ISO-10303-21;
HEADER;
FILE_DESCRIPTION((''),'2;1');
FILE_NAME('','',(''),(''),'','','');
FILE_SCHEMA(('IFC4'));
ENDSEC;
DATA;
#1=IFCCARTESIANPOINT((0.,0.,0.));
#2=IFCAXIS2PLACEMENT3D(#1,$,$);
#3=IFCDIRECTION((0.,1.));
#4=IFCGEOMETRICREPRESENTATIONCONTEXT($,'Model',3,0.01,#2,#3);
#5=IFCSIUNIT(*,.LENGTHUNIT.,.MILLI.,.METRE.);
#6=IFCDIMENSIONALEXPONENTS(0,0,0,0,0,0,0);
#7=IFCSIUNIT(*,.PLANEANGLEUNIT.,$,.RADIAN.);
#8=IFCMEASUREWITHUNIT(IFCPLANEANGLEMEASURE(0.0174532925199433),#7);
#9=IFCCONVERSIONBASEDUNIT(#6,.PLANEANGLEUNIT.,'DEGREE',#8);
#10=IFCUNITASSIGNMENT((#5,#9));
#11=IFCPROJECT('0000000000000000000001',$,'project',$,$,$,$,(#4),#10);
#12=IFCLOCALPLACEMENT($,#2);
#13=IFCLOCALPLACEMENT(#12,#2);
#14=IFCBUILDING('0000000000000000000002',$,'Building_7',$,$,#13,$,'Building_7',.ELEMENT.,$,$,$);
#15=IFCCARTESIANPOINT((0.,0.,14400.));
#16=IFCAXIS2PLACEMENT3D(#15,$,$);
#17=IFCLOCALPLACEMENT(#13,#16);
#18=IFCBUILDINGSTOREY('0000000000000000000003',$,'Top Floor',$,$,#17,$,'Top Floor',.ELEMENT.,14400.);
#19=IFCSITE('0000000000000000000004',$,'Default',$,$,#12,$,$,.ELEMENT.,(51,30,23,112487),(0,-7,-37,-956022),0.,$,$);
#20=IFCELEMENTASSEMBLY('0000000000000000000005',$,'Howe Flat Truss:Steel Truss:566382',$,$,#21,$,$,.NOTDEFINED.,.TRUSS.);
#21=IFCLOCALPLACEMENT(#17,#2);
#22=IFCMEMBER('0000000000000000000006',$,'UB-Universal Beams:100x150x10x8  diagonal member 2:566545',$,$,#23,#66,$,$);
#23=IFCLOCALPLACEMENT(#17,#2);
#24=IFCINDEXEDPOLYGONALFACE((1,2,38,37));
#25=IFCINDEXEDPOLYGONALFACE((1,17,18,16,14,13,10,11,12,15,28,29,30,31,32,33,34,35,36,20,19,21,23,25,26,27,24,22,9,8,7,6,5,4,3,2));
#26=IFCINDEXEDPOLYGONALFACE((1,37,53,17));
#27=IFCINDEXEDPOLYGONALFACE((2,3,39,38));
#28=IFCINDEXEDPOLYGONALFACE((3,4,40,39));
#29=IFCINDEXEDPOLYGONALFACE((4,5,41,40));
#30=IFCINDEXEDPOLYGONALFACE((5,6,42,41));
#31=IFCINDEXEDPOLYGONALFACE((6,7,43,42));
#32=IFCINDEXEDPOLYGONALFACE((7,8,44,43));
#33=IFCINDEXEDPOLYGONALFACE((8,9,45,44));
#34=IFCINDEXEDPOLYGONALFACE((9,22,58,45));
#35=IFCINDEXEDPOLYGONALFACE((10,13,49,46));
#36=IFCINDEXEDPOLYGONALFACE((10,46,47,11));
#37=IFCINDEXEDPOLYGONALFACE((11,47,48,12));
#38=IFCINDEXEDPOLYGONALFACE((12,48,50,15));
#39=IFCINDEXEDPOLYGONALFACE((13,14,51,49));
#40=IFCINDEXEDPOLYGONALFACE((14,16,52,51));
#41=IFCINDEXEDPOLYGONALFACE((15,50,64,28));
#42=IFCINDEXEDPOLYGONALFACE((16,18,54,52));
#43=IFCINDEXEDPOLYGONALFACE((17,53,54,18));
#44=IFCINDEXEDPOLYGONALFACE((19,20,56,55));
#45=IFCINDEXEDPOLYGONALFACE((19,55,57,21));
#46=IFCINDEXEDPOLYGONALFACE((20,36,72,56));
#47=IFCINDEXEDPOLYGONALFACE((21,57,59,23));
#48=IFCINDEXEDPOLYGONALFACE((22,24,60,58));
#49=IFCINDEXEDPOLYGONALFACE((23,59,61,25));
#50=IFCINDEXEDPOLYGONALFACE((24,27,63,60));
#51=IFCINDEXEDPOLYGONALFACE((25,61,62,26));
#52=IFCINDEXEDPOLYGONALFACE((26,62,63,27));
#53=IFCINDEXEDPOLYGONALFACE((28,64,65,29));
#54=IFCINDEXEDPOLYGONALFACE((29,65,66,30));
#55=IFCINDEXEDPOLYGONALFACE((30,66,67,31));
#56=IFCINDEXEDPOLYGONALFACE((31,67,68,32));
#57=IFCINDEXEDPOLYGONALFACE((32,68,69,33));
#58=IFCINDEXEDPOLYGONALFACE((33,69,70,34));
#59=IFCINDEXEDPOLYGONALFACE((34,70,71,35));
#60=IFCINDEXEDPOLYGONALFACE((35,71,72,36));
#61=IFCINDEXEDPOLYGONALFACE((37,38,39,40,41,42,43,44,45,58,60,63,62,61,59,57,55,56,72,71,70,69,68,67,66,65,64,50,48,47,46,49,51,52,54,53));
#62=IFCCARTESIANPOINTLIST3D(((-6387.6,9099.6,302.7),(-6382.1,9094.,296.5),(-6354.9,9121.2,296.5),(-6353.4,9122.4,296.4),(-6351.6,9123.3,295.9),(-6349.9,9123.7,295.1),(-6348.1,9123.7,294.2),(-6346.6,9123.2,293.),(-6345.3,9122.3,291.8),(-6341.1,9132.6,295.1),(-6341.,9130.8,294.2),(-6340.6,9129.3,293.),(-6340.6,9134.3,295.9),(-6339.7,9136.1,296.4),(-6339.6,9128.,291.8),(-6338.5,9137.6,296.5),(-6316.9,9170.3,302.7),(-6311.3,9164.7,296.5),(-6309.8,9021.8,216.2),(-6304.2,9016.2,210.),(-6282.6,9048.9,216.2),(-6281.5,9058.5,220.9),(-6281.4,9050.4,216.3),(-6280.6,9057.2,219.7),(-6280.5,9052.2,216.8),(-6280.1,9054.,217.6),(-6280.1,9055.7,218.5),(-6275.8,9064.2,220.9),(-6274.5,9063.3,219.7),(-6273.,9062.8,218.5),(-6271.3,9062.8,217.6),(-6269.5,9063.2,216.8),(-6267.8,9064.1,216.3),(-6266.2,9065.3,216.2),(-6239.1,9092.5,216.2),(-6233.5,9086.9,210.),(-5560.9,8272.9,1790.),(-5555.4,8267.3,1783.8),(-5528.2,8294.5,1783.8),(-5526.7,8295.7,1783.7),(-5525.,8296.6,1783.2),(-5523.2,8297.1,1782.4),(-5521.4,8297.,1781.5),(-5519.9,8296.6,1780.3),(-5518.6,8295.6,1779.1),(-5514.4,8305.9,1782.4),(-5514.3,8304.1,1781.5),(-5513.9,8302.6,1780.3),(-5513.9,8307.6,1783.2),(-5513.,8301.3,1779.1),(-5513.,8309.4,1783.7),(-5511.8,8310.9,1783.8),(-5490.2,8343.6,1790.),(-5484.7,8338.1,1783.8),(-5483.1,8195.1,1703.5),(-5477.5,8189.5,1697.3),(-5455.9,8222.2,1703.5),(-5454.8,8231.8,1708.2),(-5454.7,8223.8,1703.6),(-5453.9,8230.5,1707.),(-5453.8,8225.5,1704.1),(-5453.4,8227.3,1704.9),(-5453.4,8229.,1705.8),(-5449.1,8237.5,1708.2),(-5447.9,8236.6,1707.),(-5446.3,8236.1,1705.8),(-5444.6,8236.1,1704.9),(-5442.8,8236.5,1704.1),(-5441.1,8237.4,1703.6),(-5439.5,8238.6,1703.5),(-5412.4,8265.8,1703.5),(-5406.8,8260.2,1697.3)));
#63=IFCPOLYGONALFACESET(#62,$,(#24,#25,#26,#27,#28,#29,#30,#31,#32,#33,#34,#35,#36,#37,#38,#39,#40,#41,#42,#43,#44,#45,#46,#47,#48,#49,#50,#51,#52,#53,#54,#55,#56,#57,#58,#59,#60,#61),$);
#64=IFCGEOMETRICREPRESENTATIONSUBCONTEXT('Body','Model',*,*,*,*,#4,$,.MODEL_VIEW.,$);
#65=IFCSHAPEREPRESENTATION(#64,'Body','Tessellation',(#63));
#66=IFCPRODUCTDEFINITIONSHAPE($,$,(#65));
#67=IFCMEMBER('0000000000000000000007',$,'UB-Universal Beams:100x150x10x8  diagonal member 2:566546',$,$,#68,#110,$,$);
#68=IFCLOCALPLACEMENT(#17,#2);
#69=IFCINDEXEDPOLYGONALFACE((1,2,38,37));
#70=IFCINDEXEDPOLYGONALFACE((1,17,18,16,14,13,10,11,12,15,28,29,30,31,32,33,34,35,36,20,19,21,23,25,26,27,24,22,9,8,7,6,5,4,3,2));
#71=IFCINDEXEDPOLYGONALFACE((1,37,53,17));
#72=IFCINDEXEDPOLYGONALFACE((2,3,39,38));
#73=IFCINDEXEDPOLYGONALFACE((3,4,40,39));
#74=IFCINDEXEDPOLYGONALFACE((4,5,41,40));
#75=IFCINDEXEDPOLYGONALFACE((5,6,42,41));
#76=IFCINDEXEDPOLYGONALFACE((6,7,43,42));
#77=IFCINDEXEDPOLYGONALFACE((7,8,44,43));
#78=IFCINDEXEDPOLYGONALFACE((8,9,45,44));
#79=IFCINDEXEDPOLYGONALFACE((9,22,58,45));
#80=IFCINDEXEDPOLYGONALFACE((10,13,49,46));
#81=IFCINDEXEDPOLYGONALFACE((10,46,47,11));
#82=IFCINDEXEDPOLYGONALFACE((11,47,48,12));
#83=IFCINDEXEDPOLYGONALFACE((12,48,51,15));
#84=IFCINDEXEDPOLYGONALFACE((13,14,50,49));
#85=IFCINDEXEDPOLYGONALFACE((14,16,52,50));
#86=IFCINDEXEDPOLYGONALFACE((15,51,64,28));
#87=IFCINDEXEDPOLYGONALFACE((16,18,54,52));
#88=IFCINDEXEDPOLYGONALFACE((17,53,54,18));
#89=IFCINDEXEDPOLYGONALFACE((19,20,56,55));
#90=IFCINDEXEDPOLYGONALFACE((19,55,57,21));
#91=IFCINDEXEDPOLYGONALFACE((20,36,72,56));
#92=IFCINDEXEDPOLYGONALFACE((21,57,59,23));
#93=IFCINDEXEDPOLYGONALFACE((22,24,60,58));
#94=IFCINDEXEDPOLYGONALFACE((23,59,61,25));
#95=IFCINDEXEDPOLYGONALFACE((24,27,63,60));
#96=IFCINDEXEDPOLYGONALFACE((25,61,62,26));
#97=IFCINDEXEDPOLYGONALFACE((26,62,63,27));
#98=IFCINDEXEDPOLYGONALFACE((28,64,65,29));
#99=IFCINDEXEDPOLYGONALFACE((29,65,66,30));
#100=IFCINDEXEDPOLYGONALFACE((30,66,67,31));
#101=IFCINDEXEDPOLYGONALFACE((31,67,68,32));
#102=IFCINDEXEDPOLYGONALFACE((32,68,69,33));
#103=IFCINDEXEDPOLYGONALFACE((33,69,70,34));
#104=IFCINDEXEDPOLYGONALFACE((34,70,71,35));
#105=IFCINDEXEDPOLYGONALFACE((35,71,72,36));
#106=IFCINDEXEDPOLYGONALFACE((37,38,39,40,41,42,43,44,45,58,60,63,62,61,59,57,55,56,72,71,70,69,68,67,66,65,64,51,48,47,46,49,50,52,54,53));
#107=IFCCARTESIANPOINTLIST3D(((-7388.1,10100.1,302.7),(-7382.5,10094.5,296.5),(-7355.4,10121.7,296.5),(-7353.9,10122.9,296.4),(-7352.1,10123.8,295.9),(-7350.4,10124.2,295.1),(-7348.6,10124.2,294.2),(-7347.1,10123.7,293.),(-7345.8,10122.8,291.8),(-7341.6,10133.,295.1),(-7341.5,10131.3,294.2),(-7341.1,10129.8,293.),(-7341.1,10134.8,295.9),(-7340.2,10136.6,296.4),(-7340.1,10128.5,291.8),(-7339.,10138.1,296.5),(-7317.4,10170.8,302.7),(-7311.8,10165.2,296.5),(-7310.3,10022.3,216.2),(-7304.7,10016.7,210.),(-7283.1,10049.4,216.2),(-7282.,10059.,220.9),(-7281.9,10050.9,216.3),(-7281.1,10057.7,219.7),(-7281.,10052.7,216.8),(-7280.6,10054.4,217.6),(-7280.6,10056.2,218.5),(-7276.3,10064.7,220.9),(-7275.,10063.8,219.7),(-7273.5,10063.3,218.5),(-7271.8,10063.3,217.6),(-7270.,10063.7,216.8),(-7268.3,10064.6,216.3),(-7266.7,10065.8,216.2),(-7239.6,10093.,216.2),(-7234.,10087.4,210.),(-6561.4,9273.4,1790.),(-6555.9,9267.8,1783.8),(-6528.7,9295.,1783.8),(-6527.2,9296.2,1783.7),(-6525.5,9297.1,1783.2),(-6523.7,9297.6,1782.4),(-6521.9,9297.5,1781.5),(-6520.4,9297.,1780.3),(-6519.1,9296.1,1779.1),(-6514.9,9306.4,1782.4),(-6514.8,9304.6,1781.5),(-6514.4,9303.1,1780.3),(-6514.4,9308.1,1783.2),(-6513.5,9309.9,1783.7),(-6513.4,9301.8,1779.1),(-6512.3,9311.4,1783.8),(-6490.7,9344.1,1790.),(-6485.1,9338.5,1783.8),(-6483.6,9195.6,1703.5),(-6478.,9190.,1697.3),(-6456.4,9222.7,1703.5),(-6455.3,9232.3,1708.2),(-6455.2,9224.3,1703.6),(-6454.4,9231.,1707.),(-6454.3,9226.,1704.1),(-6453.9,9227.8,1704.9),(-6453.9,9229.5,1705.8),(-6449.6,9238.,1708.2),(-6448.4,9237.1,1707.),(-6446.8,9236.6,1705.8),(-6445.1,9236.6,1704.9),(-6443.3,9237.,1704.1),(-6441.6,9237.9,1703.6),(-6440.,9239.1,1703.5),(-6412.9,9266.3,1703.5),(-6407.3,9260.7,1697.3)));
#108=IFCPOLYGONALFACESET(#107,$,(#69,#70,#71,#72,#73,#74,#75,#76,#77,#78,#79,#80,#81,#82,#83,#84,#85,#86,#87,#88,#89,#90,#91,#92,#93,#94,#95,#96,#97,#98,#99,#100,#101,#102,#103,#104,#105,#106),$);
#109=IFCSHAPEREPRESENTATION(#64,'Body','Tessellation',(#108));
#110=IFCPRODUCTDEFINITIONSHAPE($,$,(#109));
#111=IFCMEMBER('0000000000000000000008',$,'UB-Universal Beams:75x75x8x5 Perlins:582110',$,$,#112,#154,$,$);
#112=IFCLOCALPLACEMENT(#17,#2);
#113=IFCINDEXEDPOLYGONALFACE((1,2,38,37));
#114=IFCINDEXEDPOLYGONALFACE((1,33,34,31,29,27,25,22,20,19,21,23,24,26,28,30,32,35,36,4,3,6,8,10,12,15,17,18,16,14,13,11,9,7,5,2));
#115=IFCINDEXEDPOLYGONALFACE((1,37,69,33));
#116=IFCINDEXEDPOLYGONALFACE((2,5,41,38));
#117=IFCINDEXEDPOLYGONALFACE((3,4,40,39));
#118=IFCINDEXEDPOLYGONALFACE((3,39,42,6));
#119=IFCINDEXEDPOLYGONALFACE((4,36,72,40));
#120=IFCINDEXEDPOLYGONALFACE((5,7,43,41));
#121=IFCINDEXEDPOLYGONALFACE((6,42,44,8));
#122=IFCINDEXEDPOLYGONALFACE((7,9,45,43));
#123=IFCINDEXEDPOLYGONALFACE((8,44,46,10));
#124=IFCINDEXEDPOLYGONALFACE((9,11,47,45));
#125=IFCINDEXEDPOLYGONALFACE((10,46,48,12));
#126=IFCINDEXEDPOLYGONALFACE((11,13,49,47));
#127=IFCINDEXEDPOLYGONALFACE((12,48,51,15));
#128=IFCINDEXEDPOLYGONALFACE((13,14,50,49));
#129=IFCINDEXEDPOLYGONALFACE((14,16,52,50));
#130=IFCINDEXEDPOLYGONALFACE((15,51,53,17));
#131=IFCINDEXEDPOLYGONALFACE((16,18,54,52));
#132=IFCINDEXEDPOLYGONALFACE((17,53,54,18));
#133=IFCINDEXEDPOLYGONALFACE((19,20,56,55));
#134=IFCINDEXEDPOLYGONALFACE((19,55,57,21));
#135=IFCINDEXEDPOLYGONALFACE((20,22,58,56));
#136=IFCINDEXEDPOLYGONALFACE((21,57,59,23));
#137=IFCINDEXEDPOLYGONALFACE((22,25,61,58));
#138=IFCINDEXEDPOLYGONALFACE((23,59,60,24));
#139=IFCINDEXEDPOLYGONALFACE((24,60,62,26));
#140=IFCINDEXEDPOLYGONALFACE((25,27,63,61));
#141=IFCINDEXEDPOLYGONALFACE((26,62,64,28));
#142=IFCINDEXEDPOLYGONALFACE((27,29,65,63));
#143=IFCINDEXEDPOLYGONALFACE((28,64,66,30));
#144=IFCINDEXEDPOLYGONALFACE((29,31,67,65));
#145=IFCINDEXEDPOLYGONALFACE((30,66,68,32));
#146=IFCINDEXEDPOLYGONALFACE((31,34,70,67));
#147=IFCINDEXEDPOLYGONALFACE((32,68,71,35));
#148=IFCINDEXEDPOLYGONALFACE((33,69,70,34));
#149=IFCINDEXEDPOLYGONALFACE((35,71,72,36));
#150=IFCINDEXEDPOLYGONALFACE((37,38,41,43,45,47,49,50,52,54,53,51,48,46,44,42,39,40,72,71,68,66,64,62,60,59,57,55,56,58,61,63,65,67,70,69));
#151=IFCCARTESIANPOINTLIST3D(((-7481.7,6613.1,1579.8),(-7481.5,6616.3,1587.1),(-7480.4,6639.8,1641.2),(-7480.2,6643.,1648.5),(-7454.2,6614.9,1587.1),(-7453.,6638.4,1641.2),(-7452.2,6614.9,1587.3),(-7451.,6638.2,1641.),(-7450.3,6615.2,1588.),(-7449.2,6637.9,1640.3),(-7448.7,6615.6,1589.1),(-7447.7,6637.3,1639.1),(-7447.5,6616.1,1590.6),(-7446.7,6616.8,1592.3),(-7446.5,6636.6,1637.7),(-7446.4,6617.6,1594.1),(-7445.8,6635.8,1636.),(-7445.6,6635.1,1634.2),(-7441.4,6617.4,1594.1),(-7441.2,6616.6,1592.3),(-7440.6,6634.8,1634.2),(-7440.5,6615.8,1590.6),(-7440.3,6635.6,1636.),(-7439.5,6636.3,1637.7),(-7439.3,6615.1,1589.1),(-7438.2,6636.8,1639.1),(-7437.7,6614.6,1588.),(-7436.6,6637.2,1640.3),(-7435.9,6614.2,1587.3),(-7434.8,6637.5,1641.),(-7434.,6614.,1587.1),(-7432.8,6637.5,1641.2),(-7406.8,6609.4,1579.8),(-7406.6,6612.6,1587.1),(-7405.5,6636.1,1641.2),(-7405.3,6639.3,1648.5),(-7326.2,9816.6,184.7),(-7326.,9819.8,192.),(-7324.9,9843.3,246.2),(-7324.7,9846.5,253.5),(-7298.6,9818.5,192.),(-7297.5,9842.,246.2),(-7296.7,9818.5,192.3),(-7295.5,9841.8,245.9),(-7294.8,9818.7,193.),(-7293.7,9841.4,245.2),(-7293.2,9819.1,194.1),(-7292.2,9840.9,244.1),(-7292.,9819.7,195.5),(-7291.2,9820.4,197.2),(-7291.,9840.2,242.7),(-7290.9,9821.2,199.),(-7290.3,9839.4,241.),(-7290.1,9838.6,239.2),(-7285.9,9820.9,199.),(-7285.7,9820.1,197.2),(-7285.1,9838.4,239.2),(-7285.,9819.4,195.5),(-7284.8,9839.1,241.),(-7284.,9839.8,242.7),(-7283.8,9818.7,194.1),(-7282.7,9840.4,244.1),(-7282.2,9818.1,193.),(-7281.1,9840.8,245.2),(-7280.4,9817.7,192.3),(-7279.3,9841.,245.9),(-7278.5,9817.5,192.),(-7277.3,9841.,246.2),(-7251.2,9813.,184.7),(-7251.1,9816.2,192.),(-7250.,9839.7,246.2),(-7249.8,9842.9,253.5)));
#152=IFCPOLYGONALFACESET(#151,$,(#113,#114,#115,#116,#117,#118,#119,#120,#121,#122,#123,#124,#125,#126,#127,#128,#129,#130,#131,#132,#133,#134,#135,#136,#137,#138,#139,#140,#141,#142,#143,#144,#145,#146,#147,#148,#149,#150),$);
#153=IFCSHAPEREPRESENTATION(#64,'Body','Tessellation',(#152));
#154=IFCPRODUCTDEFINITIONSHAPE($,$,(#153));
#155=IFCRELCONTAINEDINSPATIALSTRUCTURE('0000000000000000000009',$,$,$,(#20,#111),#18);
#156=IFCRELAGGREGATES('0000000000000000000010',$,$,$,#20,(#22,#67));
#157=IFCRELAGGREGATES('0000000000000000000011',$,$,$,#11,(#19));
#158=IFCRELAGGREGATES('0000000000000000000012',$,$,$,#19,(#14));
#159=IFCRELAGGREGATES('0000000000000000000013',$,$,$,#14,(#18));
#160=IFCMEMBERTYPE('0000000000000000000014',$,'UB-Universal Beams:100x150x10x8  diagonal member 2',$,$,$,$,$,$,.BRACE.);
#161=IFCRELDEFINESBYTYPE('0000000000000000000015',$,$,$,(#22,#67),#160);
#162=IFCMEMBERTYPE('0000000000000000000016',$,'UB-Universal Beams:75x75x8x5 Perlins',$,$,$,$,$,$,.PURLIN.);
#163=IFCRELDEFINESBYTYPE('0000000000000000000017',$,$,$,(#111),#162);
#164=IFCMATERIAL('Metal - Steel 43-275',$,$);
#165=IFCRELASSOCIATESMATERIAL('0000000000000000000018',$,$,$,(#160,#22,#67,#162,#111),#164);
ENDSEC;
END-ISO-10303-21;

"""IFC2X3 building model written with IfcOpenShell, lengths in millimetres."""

from ifc_helpers import new_model, entity, si_unit, converted_unit, direction, frame, frame_2d, origin, place, context, subcontext, project, spatial, polyline, circle_curve, parameter, trimmed, segment, composite_curve, outline, extrude, source, transform, mapped, material, type_object, type_shapes, element, aggregate, save


model = new_model("IFC2X3")

# Units and contexts
model_context = context("Model", 3, precision=0.01, world=origin(), true_north=direction((0.0, 1.0)))
body_context = subcontext(model_context, "Body", "Model", "MODEL_VIEW")
ifc_project = project(units=[si_unit("LENGTHUNIT", "METRE", prefix="MILLI"), converted_unit("PLANEANGLEUNIT", "DEGREE", entity("IfcPlaneAngleMeasure", 0.0174532925199433), si_unit("PLANEANGLEUNIT", "RADIAN"), dimensions=[0, 0, 0, 0, 0, 0, 0])], contexts=[model_context])

# Site, building, storey
site_placement = place(None, origin())
site = spatial("IfcSite", under=ifc_project, at=site_placement, Name="Default", CompositionType="ELEMENT", RefLatitude=(51, 30, 23, 112487), RefLongitude=(0, -7, -37, -956022), RefElevation=0.0)
building_placement = place(site_placement, origin())
building = spatial("IfcBuilding", under=site, at=building_placement, Name="Building_7", LongName="Building_7", CompositionType="ELEMENT")
storey_placement = place(building_placement, frame((0.0, 0.0, 14400.0)))
storey = spatial("IfcBuildingStorey", under=building, at=storey_placement, Name="Top Floor", LongName="Top Floor", CompositionType="ELEMENT", Elevation=14400.0)

# Shared definitions
ifc_material = material(Name="Metal - Steel 43-275")

# Element assembly
assembly_1_placement = place(storey_placement, origin())
assembly_1 = element("IfcElementAssembly", 1, at=assembly_1_placement, inside=storey, Name="Howe Flat Truss:Steel Truss:566382", AssemblyPlace="NOTDEFINED", PredefinedType="TRUSS")

# Members
member_type_1 = type_object("IfcMemberType", Name="UB-Universal Beams:100x150x10x8  diagonal member 2", PredefinedType="BRACE", material=ifc_material)
shared_shape_1 = source(origin(), body_context, "Body", "SweptSolid", [
    extrude(outline(composite_curve([segment(polyline([(-50.0, -65.0), (-50.0, -75.0)]), True, "CONTINUOUS"), segment(polyline([(-50.0, -75.0), (50.0, -75.0)]), True, "CONTINUOUS"), segment(polyline([(50.0, -75.0), (50.0, -65.0)]), True, "CONTINUOUS"), segment(polyline([(50.0, -65.0), (11.6, -65.0)]), True, "CONTINUOUS"), segment(trimmed(circle_curve(frame_2d((11.6, -57.4), x_axis=(1.0, 0.0)), 7.6), [parameter(180.0)], [parameter(270.0)], True, "PARAMETER"), False, "CONTINUOUS"), segment(polyline([(4.0, -57.4), (4.0, 57.4)]), True, "CONTINUOUS"), segment(trimmed(circle_curve(frame_2d((11.6, 57.4), x_axis=(1.0, 0.0)), 7.6), [parameter(90.0)], [parameter(180.0)], True, "PARAMETER"), False, "CONTINUOUS"), segment(polyline([(11.6, 65.0), (50.0, 65.0)]), True, "CONTINUOUS"), segment(polyline([(50.0, 65.0), (50.0, 75.0)]), True, "CONTINUOUS"), segment(polyline([(50.0, 75.0), (-50.0, 75.0)]), True, "CONTINUOUS"), segment(polyline([(-50.0, 75.0), (-50.0, 65.0)]), True, "CONTINUOUS"), segment(polyline([(-50.0, 65.0), (-11.6, 65.0)]), True, "CONTINUOUS"), segment(trimmed(circle_curve(frame_2d((-11.6, 57.4), x_axis=(1.0, 0.0)), 7.6), [parameter(360.0)], [parameter(90.0)], True, "PARAMETER"), False, "CONTINUOUS"), segment(polyline([(-4.0, 57.4), (-4.0, -57.4)]), True, "CONTINUOUS"), segment(trimmed(circle_curve(frame_2d((-11.6, -57.4), x_axis=(1.0, 0.0)), 7.6), [parameter(270.0)], [parameter(360.0)], True, "PARAMETER"), False, "CONTINUOUS"), segment(polyline([(-11.6, -65.0), (-50.0, -65.0)]), True, "CONTINUOUS")], self_intersect=False)), frame((-945.9, 0.0, 0.0), z_axis=(-1.0, 0.0, 0.0), x_axis=(0.0, -1.0, 0.0)), (0.0, 0.0, -1.0), 1891.8),
])
type_shapes(member_type_1, [shared_shape_1])
member_1_placement = place(assembly_1_placement, frame((-5897.2, 8679.9, 1000.0), z_axis=(0.555916, -0.555916, -0.617992), x_axis=(-0.436986, 0.436986, -0.786184)))
member_1 = element("IfcMember", 2, at=member_1_placement, type_object=member_type_1, material=ifc_material, Name="UB-Universal Beams:100x150x10x8  diagonal member 2:566545", context=body_context, shape_type="MappedRepresentation", body=[
    mapped(shared_shape_1, transform((0.0, 0.0, 0.0), scale=1.0)),
])
member_2_placement = place(assembly_1_placement, frame((-6897.7, 9680.4, 1000.0), z_axis=(0.555916, -0.555916, -0.617992), x_axis=(-0.436986, 0.436986, -0.786184)))
member_2 = element("IfcMember", 3, at=member_2_placement, type_object=member_type_1, material=ifc_material, Name="UB-Universal Beams:100x150x10x8  diagonal member 2:566546", context=body_context, shape_type="MappedRepresentation", body=[
    mapped(shared_shape_1, transform((0.0, 0.0, 0.0), scale=1.0)),
])
aggregate(assembly_1, [member_1, member_2])

# Member
member_type_2 = type_object("IfcMemberType", Name="UB-Universal Beams:75x75x8x5 Perlins", PredefinedType="PURLIN", material=ifc_material)
shared_shape_2 = source(origin(), body_context, "Body", "SweptSolid", [
    extrude(outline(composite_curve([segment(polyline([(29.5, -37.5), (37.5, -37.5)]), True, "CONTINUOUS"), segment(polyline([(37.5, -37.5), (37.5, 37.5)]), True, "CONTINUOUS"), segment(polyline([(37.5, 37.5), (29.5, 37.5)]), True, "CONTINUOUS"), segment(polyline([(29.5, 37.5), (29.5, 10.1)]), True, "CONTINUOUS"), segment(trimmed(circle_curve(frame_2d((21.9, 10.1), x_axis=(0.0, 1.0)), 7.6), [parameter(180.0)], [parameter(270.0)], True, "PARAMETER"), False, "CONTINUOUS"), segment(polyline([(21.9, 2.5), (-21.9, 2.5)]), True, "CONTINUOUS"), segment(trimmed(circle_curve(frame_2d((-21.9, 10.1), x_axis=(0.0, 1.0)), 7.6), [parameter(90.0)], [parameter(180.0)], True, "PARAMETER"), False, "CONTINUOUS"), segment(polyline([(-29.5, 10.1), (-29.5, 37.5)]), True, "CONTINUOUS"), segment(polyline([(-29.5, 37.5), (-37.5, 37.5)]), True, "CONTINUOUS"), segment(polyline([(-37.5, 37.5), (-37.5, -37.5)]), True, "CONTINUOUS"), segment(polyline([(-37.5, -37.5), (-29.5, -37.5)]), True, "CONTINUOUS"), segment(polyline([(-29.5, -37.5), (-29.5, -10.1)]), True, "CONTINUOUS"), segment(trimmed(circle_curve(frame_2d((-21.9, -10.1), x_axis=(0.0, 1.0)), 7.6), [parameter(360.0)], [parameter(90.0)], True, "PARAMETER"), False, "CONTINUOUS"), segment(polyline([(-21.9, -2.5), (21.9, -2.5)]), True, "CONTINUOUS"), segment(trimmed(circle_curve(frame_2d((21.9, -10.1), x_axis=(0.0, 1.0)), 7.6), [parameter(270.0)], [parameter(360.0)], True, "PARAMETER"), False, "CONTINUOUS"), segment(polyline([(29.5, -10.1), (29.5, -37.5)]), True, "CONTINUOUS")], self_intersect=False)), frame((-1874.2, 0.0, 0.0), z_axis=(1.0, 0.0, 0.0), x_axis=(0.0, 0.0, -1.0)), (0.0, 0.0, 1.0), 3497.6),
])
type_shapes(member_type_2, [shared_shape_2])
member_3_placement = place(storey_placement, frame((-7360.2, 8342.8, 866.6), z_axis=(0.01934, 0.398389, 0.917013), x_axis=(0.044463, 0.915934, -0.398858)))
element("IfcMember", 4, at=member_3_placement, inside=storey, type_object=member_type_2, material=ifc_material, Name="UB-Universal Beams:75x75x8x5 Perlins:582110", context=body_context, shape_type="MappedRepresentation", body=[
    mapped(shared_shape_2, transform((0.0, 0.0, 0.0), scale=1.0)),
])

save(model, "model.ifc")
